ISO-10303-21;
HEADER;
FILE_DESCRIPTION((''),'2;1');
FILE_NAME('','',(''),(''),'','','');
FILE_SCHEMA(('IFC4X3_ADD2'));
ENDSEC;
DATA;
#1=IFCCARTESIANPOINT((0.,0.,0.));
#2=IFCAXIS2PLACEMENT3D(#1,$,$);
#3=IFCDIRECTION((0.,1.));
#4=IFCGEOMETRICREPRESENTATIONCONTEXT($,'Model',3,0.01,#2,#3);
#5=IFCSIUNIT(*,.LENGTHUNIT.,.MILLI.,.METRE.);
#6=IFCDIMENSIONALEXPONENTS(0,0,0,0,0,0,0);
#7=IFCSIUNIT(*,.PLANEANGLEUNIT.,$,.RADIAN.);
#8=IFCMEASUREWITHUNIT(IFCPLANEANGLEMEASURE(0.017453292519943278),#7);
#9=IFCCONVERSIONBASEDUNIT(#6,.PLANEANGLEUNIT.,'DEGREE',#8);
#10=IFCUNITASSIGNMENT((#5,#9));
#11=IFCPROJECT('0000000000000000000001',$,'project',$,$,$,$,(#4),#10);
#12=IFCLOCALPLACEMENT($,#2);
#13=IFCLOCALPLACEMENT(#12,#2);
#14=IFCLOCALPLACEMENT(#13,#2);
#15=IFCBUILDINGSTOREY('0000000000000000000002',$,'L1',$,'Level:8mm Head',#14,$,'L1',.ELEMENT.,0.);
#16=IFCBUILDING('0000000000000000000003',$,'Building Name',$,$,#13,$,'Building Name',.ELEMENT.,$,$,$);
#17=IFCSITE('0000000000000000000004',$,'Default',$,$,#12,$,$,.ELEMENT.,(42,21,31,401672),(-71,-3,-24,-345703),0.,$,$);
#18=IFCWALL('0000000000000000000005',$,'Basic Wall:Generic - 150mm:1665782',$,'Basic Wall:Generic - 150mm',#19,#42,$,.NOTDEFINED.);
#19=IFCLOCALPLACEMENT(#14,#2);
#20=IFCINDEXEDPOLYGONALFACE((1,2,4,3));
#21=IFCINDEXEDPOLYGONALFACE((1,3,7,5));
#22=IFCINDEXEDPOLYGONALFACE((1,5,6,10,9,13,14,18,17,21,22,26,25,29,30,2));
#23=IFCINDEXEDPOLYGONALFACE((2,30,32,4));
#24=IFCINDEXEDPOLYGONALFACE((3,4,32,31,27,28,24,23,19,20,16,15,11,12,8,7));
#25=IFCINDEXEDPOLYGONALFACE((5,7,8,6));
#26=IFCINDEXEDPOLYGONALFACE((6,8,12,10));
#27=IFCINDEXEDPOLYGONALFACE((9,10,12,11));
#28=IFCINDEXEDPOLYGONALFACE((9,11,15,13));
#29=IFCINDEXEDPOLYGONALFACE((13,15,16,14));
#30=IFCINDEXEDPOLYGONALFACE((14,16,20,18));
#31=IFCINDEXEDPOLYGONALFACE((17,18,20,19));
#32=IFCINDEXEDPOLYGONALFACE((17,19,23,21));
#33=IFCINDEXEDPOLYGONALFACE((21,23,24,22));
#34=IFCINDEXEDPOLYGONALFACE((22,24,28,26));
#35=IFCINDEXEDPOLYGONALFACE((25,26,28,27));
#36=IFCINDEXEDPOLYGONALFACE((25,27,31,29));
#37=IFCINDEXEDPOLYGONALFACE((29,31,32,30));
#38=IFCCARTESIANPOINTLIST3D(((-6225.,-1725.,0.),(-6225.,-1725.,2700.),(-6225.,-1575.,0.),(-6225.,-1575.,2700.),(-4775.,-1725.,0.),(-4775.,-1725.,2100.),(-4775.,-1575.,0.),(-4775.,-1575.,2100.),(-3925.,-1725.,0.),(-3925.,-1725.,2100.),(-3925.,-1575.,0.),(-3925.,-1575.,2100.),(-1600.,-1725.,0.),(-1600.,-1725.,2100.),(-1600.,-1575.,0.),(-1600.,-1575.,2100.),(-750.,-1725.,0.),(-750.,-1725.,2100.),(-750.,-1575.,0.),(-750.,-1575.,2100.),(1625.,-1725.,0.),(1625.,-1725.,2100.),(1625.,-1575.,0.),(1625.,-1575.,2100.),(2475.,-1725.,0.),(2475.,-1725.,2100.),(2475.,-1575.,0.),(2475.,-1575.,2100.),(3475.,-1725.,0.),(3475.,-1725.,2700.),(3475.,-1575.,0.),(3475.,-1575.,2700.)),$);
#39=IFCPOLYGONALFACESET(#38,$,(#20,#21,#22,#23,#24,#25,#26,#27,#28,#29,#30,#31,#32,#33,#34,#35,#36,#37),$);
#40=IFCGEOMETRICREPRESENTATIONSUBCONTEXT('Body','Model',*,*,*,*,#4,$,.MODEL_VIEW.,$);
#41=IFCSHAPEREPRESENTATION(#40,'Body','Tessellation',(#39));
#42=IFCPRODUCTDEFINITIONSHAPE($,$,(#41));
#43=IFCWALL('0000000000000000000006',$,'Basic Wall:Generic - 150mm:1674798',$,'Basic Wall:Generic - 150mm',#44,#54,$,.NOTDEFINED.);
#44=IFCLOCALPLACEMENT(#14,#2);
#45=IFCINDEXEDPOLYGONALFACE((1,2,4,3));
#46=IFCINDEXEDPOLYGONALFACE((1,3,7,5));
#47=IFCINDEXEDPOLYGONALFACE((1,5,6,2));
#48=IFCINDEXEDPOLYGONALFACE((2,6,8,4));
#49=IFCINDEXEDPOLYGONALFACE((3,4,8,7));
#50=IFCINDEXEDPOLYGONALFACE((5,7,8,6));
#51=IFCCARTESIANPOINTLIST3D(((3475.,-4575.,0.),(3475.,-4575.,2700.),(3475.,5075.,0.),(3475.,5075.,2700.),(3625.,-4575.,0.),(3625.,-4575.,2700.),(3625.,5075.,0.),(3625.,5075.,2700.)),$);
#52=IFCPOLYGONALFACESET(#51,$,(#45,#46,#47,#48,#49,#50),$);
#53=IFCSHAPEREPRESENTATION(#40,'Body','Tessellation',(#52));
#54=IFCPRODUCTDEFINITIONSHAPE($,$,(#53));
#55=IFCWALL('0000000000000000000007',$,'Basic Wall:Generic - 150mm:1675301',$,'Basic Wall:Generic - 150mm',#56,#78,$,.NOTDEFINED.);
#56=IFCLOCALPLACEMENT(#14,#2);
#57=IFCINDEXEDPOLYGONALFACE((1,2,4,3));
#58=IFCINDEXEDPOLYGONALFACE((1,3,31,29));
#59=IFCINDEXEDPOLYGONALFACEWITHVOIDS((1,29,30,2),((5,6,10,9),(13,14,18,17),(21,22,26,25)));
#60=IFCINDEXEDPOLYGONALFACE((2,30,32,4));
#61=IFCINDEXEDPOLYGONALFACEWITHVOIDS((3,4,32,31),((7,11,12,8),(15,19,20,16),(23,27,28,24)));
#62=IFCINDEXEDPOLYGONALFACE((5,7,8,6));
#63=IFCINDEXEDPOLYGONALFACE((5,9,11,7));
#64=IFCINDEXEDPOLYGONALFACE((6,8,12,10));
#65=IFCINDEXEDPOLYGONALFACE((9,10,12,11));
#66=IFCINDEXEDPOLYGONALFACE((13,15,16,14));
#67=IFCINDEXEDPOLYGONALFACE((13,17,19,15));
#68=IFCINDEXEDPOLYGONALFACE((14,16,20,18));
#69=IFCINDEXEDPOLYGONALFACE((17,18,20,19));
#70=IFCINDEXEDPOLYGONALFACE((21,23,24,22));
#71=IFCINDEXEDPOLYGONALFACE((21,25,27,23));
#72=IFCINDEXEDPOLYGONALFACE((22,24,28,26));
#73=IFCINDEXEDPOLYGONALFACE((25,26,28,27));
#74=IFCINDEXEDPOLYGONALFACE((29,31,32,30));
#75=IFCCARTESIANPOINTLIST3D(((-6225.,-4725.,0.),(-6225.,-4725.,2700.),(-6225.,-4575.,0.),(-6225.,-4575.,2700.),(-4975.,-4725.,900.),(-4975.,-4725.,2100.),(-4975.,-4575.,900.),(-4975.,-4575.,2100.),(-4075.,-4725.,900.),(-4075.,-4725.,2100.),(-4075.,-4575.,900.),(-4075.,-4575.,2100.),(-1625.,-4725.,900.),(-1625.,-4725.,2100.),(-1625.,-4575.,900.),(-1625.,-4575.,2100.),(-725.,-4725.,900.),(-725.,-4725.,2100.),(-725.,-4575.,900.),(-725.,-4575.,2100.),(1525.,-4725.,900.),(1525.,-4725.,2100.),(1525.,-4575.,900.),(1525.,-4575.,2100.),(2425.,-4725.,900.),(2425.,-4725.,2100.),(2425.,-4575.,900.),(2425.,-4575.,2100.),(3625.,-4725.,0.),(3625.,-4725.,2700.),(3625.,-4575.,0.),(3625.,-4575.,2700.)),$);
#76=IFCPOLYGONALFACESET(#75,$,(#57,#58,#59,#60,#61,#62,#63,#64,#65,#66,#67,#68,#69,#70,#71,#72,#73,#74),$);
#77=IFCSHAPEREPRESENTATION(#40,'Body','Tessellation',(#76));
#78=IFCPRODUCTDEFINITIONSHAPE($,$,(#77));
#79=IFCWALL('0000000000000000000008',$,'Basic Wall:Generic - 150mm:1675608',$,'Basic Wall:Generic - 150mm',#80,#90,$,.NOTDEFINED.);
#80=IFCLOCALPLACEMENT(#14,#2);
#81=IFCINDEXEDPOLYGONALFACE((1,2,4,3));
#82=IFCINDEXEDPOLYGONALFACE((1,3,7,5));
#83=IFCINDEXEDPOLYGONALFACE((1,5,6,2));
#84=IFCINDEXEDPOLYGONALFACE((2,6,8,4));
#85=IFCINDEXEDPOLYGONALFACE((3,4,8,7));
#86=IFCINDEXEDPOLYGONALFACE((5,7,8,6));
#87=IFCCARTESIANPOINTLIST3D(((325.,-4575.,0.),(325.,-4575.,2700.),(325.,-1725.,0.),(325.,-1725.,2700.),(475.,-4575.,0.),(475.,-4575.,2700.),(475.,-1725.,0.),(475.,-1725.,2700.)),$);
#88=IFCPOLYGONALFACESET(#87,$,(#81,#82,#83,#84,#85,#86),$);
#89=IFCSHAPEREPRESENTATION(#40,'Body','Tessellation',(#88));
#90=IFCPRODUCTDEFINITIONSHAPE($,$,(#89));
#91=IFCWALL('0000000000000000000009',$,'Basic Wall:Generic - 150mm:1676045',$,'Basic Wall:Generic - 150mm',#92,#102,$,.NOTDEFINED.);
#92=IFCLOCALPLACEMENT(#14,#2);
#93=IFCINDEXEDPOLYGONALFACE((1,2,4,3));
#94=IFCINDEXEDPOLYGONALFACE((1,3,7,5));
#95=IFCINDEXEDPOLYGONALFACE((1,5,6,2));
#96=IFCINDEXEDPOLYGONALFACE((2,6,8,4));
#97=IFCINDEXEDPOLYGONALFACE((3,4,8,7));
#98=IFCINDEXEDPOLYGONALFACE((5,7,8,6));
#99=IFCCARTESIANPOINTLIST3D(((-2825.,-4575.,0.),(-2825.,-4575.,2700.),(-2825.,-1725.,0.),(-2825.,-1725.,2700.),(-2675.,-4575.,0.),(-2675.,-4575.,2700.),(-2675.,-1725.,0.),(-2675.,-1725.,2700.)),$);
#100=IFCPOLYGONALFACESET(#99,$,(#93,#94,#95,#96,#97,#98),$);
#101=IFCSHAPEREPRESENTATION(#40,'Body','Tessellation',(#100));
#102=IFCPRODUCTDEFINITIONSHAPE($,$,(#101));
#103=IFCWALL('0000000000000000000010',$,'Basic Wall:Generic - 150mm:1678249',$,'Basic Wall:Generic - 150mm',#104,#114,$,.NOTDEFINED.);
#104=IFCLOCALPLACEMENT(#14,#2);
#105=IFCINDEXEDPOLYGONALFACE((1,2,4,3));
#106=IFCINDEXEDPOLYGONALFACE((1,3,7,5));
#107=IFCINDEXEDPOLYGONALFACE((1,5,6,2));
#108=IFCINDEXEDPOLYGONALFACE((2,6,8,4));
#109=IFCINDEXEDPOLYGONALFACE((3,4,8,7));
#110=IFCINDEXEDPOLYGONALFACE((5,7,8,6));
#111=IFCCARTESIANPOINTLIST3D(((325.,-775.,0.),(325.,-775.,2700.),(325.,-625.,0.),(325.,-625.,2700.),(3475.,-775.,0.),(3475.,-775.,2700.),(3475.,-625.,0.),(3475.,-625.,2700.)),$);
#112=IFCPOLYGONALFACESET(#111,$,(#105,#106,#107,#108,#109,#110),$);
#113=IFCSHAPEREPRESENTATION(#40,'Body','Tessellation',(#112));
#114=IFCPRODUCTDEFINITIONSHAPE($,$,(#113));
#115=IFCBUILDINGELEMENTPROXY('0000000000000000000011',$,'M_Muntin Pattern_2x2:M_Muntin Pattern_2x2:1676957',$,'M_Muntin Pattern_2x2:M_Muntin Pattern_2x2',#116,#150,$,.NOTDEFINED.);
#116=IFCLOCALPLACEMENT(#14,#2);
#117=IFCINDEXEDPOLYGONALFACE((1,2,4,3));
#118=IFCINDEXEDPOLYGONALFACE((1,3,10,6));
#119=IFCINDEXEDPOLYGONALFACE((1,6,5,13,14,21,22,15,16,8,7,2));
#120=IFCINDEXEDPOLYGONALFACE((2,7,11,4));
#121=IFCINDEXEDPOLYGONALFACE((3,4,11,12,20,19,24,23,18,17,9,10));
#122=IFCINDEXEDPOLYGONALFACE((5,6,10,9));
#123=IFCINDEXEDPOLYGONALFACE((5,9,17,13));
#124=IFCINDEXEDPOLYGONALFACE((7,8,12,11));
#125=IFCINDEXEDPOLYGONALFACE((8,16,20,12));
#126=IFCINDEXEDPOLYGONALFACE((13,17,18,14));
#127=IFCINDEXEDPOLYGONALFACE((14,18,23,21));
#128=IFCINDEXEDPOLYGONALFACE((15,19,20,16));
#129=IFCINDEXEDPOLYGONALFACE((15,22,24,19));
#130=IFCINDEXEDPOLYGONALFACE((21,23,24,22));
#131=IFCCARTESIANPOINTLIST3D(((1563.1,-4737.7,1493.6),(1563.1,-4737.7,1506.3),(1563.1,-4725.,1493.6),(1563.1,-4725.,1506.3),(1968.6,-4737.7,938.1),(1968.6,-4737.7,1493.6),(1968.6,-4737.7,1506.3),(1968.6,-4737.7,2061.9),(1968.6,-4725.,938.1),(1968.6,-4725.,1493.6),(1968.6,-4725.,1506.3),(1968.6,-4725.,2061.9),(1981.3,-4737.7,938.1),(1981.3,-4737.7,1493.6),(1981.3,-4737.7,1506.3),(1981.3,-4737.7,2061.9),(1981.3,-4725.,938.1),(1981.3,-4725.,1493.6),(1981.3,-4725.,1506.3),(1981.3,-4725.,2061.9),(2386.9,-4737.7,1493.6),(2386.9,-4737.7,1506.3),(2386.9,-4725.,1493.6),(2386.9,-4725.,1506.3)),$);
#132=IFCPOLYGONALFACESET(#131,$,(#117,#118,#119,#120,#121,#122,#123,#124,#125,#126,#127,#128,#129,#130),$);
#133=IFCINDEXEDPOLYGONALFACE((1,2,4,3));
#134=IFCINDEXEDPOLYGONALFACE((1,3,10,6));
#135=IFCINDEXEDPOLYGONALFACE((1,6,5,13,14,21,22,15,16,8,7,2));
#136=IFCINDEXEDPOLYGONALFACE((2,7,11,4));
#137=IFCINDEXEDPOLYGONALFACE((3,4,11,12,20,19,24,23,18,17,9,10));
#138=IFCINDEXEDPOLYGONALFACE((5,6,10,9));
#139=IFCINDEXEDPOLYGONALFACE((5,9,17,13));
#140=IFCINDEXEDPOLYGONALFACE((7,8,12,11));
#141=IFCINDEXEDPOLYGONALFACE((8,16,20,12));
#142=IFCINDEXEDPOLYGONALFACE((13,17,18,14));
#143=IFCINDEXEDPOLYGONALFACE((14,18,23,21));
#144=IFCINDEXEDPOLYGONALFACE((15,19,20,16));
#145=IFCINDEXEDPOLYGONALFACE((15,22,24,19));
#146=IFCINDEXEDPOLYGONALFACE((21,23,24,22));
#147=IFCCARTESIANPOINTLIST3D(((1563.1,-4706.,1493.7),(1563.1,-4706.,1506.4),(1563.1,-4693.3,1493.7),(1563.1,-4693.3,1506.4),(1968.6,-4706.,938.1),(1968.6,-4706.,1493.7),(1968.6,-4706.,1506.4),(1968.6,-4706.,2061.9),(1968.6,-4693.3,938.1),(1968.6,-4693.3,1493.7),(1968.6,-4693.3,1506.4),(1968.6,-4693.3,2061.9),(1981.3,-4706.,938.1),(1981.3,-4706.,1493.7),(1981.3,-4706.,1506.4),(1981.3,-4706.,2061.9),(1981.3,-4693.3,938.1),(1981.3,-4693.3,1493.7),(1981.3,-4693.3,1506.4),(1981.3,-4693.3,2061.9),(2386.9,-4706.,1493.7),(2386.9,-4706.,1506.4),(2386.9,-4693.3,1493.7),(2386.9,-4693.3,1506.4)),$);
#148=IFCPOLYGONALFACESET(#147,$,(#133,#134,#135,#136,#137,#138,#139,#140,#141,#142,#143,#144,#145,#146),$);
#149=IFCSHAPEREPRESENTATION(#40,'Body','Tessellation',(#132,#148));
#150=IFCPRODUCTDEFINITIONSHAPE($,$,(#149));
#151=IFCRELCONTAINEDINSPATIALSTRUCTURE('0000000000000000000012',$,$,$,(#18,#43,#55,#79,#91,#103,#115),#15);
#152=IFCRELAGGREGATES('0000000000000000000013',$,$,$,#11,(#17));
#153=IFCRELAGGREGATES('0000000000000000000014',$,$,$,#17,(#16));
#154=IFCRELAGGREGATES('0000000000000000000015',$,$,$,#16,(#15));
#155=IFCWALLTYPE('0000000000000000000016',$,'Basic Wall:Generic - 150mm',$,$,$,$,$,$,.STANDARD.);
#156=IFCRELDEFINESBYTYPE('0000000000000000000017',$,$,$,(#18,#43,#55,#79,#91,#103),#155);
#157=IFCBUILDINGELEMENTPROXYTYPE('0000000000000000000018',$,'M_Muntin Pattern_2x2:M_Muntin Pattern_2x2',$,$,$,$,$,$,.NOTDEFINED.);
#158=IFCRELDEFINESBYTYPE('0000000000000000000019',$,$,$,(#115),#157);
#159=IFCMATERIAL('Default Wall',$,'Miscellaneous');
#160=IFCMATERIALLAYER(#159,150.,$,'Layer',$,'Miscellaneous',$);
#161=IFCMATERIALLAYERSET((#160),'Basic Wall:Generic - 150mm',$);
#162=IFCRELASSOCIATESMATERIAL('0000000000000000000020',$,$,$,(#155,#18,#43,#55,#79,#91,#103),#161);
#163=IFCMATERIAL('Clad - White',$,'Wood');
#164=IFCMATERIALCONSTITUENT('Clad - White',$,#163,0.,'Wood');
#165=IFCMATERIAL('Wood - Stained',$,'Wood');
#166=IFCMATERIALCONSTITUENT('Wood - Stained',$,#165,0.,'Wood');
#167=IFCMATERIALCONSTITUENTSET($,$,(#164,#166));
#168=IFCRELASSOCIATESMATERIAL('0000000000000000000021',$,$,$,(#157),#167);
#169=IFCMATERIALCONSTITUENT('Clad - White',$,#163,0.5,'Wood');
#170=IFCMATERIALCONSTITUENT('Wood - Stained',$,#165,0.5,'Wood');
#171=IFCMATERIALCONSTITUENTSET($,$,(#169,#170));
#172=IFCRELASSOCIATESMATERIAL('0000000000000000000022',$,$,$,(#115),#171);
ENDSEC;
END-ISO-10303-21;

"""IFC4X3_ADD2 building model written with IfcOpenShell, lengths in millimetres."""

from ifc_helpers import new_model, entity, si_unit, converted_unit, direction, frame, frame_2d, origin, place, context, subcontext, project, spatial, polyline, rectangle, outline, extrude, source, transform, mapped, material, layer, layer_set, constituent, constituent_set, type_object, type_shapes, element, save


model = new_model("IFC4X3_ADD2")

# Units and contexts
model_context = context("Model", 3, precision=0.01, world=origin(), true_north=direction((0.0, 1.0)))
body_context = subcontext(model_context, "Body", "Model", "MODEL_VIEW")
ifc_project = project(units=[si_unit("LENGTHUNIT", "METRE", prefix="MILLI"), converted_unit("PLANEANGLEUNIT", "DEGREE", entity("IfcPlaneAngleMeasure", 0.017453292519943278), si_unit("PLANEANGLEUNIT", "RADIAN"), dimensions=[0, 0, 0, 0, 0, 0, 0])], contexts=[model_context])

# Site, building, storey
site_placement = place(None, origin())
site = spatial("IfcSite", under=ifc_project, at=site_placement, Name="Default", CompositionType="ELEMENT", RefLatitude=(42, 21, 31, 401672), RefLongitude=(-71, -3, -24, -345703), RefElevation=0.0)
building_placement = place(site_placement, origin())
building = spatial("IfcBuilding", under=site, at=building_placement, Name="Building Name", LongName="Building Name", CompositionType="ELEMENT")
storey_placement = place(building_placement, origin())
storey = spatial("IfcBuildingStorey", under=building, at=storey_placement, Name="L1", ObjectType="Level:8mm Head", LongName="L1", CompositionType="ELEMENT", Elevation=0.0)

# Wall, openings
ifc_material_1 = material(Name="Default Wall", Category="Miscellaneous")
ifc_layer = layer(ifc_material_1, 150.0, Name="Layer", Category="Miscellaneous")
ifc_layer_set = layer_set([ifc_layer], Name="Basic Wall:Generic - 150mm")
wall_type = type_object("IfcWallType", Name="Basic Wall:Generic - 150mm", PredefinedType="STANDARD", material=ifc_layer_set)
wall_1_placement = place(storey_placement, frame((3475.0, -1650.0, 0.0), z_axis=(0.0, 0.0, 1.0), x_axis=(-1.0, 0.0, 0.0)))
wall_1 = element("IfcWall", 1, at=wall_1_placement, inside=storey, type_object=wall_type, material=ifc_layer_set, Name="Basic Wall:Generic - 150mm:1665782", ObjectType="Basic Wall:Generic - 150mm", PredefinedType="NOTDEFINED", context=body_context, shape_type="SweptSolid", body=[
    extrude(rectangle(XDim=9700.0, YDim=150.0, at=frame_2d((4850.0, 0.0), x_axis=(1.0, 0.0))), origin(), (0.0, 0.0, 1.0), 2700.0),
])
opening_1_placement = place(wall_1_placement, frame((7400.0, -75.0, 0.0)))
element("IfcOpeningElement", 2, at=opening_1_placement, cuts=wall_1, PredefinedType="OPENING", context=body_context, shape_type="SweptSolid", body=[
    extrude(rectangle(XDim=2100.0, YDim=850.0, at=frame_2d((1050.0, 425.0), x_axis=(1.0, 0.0))), frame((0.0, 0.0, 0.0), z_axis=(0.0, 1.0, 0.0), x_axis=(0.0, 0.0, 1.0)), (0.0, 0.0, 1.0), 150.0),
])
opening_2_placement = place(wall_1_placement, frame((4225.0, -75.0, 0.0)))
element("IfcOpeningElement", 3, at=opening_2_placement, cuts=wall_1, PredefinedType="OPENING", context=body_context, shape_type="SweptSolid", body=[
    extrude(rectangle(XDim=2100.0, YDim=850.0, at=frame_2d((1050.0, 425.0), x_axis=(1.0, 0.0))), frame((0.0, 0.0, 0.0), z_axis=(0.0, 1.0, 0.0), x_axis=(0.0, 0.0, 1.0)), (0.0, 0.0, 1.0), 150.0),
])
opening_3_placement = place(wall_1_placement, frame((1000.0, -75.0, 0.0)))
element("IfcOpeningElement", 4, at=opening_3_placement, cuts=wall_1, PredefinedType="OPENING", context=body_context, shape_type="SweptSolid", body=[
    extrude(rectangle(XDim=2100.0, YDim=850.0, at=frame_2d((1050.0, 425.0), x_axis=(1.0, 0.0))), frame((0.0, 0.0, 0.0), z_axis=(0.0, 1.0, 0.0), x_axis=(0.0, 0.0, 1.0)), (0.0, 0.0, 1.0), 150.0),
])

# Wall
wall_2_placement = place(storey_placement, frame((3550.0, -4575.0, 0.0), z_axis=(0.0, 0.0, 1.0), x_axis=(0.0, 1.0, 0.0)))
element("IfcWall", 5, at=wall_2_placement, inside=storey, type_object=wall_type, material=ifc_layer_set, Name="Basic Wall:Generic - 150mm:1674798", ObjectType="Basic Wall:Generic - 150mm", PredefinedType="NOTDEFINED", context=body_context, shape_type="SweptSolid", body=[
    extrude(rectangle(XDim=9650.0, YDim=150.0, at=frame_2d((4825.0, 0.0), x_axis=(-1.0, 0.0))), origin(), (0.0, 0.0, 1.0), 2700.0),
])

# Wall, openings
wall_3_placement = place(storey_placement, frame((-6225.0, -4650.0, 0.0)))
wall_3 = element("IfcWall", 6, at=wall_3_placement, inside=storey, type_object=wall_type, material=ifc_layer_set, Name="Basic Wall:Generic - 150mm:1675301", ObjectType="Basic Wall:Generic - 150mm", PredefinedType="NOTDEFINED", context=body_context, shape_type="SweptSolid", body=[
    extrude(rectangle(XDim=9850.0, YDim=150.0, at=frame_2d((4925.0, 0.0), x_axis=(-1.0, 0.0))), origin(), (0.0, 0.0, 1.0), 2700.0),
])
opening_4_placement = place(wall_3_placement, frame((8650.0, 75.0, 900.0)))
element("IfcOpeningElement", 7, at=opening_4_placement, cuts=wall_3, PredefinedType="OPENING", context=body_context, shape_type="SweptSolid", body=[
    extrude(rectangle(XDim=1200.0, YDim=900.0, at=frame_2d((600.0, 450.0), x_axis=(-1.0, 0.0))), frame((0.0, 0.0, 0.0), z_axis=(0.0, -1.0, 0.0), x_axis=(0.0, 0.0, 1.0)), (0.0, 0.0, 1.0), 150.0),
])
opening_5_placement = place(wall_3_placement, frame((5500.0, 75.0, 900.0)))
element("IfcOpeningElement", 8, at=opening_5_placement, cuts=wall_3, PredefinedType="OPENING", context=body_context, shape_type="SweptSolid", body=[
    extrude(rectangle(XDim=1200.0, YDim=900.0, at=frame_2d((600.0, 450.0), x_axis=(-1.0, 0.0))), frame((0.0, 0.0, 0.0), z_axis=(0.0, -1.0, 0.0), x_axis=(0.0, 0.0, 1.0)), (0.0, 0.0, 1.0), 150.0),
])
opening_6_placement = place(wall_3_placement, frame((2150.0, 75.0, 900.0)))
element("IfcOpeningElement", 9, at=opening_6_placement, cuts=wall_3, PredefinedType="OPENING", context=body_context, shape_type="SweptSolid", body=[
    extrude(rectangle(XDim=1200.0, YDim=900.0, at=frame_2d((600.0, 450.0), x_axis=(-1.0, 0.0))), frame((0.0, 0.0, 0.0), z_axis=(0.0, -1.0, 0.0), x_axis=(0.0, 0.0, 1.0)), (0.0, 0.0, 1.0), 150.0),
])

# Walls
wall_4_placement = place(storey_placement, frame((400.0, -1725.0, 0.0), z_axis=(0.0, 0.0, 1.0), x_axis=(0.0, -1.0, 0.0)))
element("IfcWall", 10, at=wall_4_placement, inside=storey, type_object=wall_type, material=ifc_layer_set, Name="Basic Wall:Generic - 150mm:1675608", ObjectType="Basic Wall:Generic - 150mm", PredefinedType="NOTDEFINED", context=body_context, shape_type="SweptSolid", body=[
    extrude(rectangle(XDim=2850.0, YDim=150.0, at=frame_2d((1425.0, 0.0), x_axis=(-1.0, 0.0))), origin(), (0.0, 0.0, 1.0), 2700.0),
])
wall_5_placement = place(storey_placement, frame((-2750.0, -1725.0, 0.0), z_axis=(0.0, 0.0, 1.0), x_axis=(0.0, -1.0, 0.0)))
element("IfcWall", 11, at=wall_5_placement, inside=storey, type_object=wall_type, material=ifc_layer_set, Name="Basic Wall:Generic - 150mm:1676045", ObjectType="Basic Wall:Generic - 150mm", PredefinedType="NOTDEFINED", context=body_context, shape_type="SweptSolid", body=[
    extrude(rectangle(XDim=2850.0, YDim=150.0, at=frame_2d((1425.0, 0.0), x_axis=(-1.0, 0.0))), origin(), (0.0, 0.0, 1.0), 2700.0),
])
wall_6_placement = place(storey_placement, frame((3475.0, -700.0, 0.0), z_axis=(0.0, 0.0, 1.0), x_axis=(-1.0, 0.0, 0.0)))
element("IfcWall", 12, at=wall_6_placement, inside=storey, type_object=wall_type, material=ifc_layer_set, Name="Basic Wall:Generic - 150mm:1678249", ObjectType="Basic Wall:Generic - 150mm", PredefinedType="NOTDEFINED", context=body_context, shape_type="SweptSolid", body=[
    extrude(rectangle(XDim=3150.0, YDim=150.0, at=frame_2d((1575.0, 0.0), x_axis=(-1.0, 0.0))), origin(), (0.0, 0.0, 1.0), 2700.0),
])

# Building element proxy
ifc_material_2 = material(Name="Clad - White", Category="Wood")
ifc_constituent_1 = constituent(ifc_material_2, Name="Clad - White", Category="Wood", fraction=0.5)
ifc_material_3 = material(Name="Wood - Stained", Category="Wood")
ifc_constituent_2 = constituent(ifc_material_3, Name="Wood - Stained", Category="Wood", fraction=0.5)
ifc_constituent_set_1 = constituent_set(constituents=[ifc_constituent_1, ifc_constituent_2])
ifc_constituent_3 = constituent(ifc_material_2, Name="Clad - White", Category="Wood", fraction=0.0)
ifc_constituent_4 = constituent(ifc_material_3, Name="Wood - Stained", Category="Wood", fraction=0.0)
ifc_constituent_set_2 = constituent_set(constituents=[ifc_constituent_3, ifc_constituent_4])
building_element_proxy_type_1 = type_object("IfcBuildingElementProxyType", Name="M_Muntin Pattern_2x2:M_Muntin Pattern_2x2", PredefinedType="NOTDEFINED", material=ifc_constituent_set_2)
shared_shape_1 = source(origin(), body_context, "Body", "SweptSolid", [
    extrude(outline(polyline([(6.4, -6.4), (561.9, -6.4), (561.9, 6.3), (6.4, 6.3), (6.4, 411.9), (-6.3, 411.9), (-6.3, 6.3), (-561.9, 6.3), (-561.9, -6.4), (-6.3, -6.4), (-6.3, -411.9), (6.4, -411.9), (6.4, -6.4)])), frame((0.0, -22.2, 561.9), z_axis=(0.0, 1.0, 0.0), x_axis=(0.0, 0.0, 1.0)), (0.0, 0.0, 1.0), 12.7),
    extrude(outline(polyline([(6.4, -6.4), (561.9, -6.4), (561.9, 6.3), (6.4, 6.3), (6.4, 411.9), (-6.3, 411.9), (-6.3, 6.3), (-561.9, 6.3), (-561.9, -6.4), (-6.3, -6.4), (-6.3, -411.9), (6.4, -411.9), (6.4, -6.4)])), frame((0.0, 9.5, 561.9), z_axis=(0.0, 1.0, 0.0), x_axis=(0.0, 0.0, 1.0)), (0.0, 0.0, 1.0), 12.7),
])
type_shapes(building_element_proxy_type_1, [shared_shape_1])
proxy_1_placement = place(storey_placement, frame((1975.0, -4715.5, 938.1)))
element("IfcBuildingElementProxy", 13, at=proxy_1_placement, inside=storey, type_object=building_element_proxy_type_1, material=ifc_constituent_set_1, Name="M_Muntin Pattern_2x2:M_Muntin Pattern_2x2:1676957", ObjectType="M_Muntin Pattern_2x2:M_Muntin Pattern_2x2", PredefinedType="NOTDEFINED", context=body_context, shape_type="MappedRepresentation", body=[
    mapped(shared_shape_1, transform((0.0, 0.0, 0.0), scale=1.0)),
])

save(model, "model.ifc")
